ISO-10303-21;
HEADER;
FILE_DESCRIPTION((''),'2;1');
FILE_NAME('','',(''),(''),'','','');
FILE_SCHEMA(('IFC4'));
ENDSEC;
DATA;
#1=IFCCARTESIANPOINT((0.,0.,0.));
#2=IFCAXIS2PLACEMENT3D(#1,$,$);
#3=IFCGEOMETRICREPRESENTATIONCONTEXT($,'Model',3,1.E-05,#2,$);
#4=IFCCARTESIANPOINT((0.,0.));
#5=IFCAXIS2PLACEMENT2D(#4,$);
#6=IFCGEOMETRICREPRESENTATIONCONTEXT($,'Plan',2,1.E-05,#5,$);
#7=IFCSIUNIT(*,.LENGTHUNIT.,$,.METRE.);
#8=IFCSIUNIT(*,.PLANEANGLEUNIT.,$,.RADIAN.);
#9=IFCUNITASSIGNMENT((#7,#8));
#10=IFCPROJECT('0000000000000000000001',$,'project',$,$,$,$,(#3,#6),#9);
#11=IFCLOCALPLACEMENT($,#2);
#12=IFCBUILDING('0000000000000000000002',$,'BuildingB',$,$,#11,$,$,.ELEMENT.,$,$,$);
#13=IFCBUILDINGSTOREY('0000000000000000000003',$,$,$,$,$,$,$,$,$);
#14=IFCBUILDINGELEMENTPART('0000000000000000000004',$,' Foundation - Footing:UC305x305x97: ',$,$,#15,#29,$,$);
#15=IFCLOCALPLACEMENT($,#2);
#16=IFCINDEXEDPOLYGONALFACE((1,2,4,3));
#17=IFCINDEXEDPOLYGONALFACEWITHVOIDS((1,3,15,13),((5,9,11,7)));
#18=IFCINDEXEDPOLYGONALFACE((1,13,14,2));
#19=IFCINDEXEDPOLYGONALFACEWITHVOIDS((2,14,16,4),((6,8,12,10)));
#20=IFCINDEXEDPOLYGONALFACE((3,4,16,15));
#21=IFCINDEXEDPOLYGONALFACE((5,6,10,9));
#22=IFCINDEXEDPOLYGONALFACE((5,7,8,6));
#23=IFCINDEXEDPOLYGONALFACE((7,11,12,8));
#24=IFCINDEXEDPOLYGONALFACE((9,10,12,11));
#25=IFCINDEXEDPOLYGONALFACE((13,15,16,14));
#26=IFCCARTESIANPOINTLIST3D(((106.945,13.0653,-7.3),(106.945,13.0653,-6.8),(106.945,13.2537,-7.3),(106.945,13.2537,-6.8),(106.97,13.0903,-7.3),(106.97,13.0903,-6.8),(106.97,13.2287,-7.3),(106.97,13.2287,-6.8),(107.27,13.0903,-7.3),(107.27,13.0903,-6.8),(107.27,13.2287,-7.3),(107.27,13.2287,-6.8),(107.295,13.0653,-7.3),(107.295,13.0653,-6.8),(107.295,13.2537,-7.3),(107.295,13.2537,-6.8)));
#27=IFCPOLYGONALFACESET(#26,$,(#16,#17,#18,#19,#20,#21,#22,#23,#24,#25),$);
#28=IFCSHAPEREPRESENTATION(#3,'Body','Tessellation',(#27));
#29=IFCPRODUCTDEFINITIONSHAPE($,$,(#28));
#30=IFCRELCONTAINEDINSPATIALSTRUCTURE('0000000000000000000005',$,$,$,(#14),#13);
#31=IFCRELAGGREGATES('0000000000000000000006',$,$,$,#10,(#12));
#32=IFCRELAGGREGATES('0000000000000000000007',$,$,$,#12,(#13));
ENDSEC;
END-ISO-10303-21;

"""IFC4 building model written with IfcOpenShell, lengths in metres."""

from ifc_helpers import new_model, si_unit, origin, origin_2d, place, context, project, spatial, polyline, outline, extrude, element, save


model = new_model("IFC4")

# Units and contexts
model_context = context("Model", 3, precision=1e-05, world=origin())
plan_context = context("Plan", 2, precision=1e-05, world=origin_2d())
ifc_project = project(units=[si_unit("LENGTHUNIT", "METRE"), si_unit("PLANEANGLEUNIT", "RADIAN")], contexts=[model_context, plan_context])

# Building, storey
building_placement = place(None, origin())
building = spatial("IfcBuilding", under=ifc_project, at=building_placement, Name="BuildingB", CompositionType="ELEMENT")
storey = spatial("IfcBuildingStorey", under=building)

# Building element part, opening
building_element_part_1 = element("IfcBuildingElementPart", 1, inside=storey, Name=" Foundation - Footing:UC305x305x97: ", context=model_context, shape_type="SweptSolid", body=[
    extrude(outline(polyline([(107.295, 13.0653, -7.3), (107.295, 13.2537, -7.3), (106.945, 13.2537, -7.3), (106.945, 13.0653, -7.3), (107.295, 13.0653, -7.3)])), None, (0.0, 0.0, 1.0), 0.5),
])
element("IfcOpeningElement", 2, inside=storey, cuts=building_element_part_1, context=model_context, shape_type="SweptSolid", body=[
    extrude(outline(polyline([(107.27, 13.0903, -7.3), (107.27, 13.2287, -7.3), (106.97, 13.2287, -7.3), (106.97, 13.0903, -7.3), (107.27, 13.0903, -7.3)])), None, (0.0, 0.0, 1.0), 0.5),
])

save(model, "model.ifc")
